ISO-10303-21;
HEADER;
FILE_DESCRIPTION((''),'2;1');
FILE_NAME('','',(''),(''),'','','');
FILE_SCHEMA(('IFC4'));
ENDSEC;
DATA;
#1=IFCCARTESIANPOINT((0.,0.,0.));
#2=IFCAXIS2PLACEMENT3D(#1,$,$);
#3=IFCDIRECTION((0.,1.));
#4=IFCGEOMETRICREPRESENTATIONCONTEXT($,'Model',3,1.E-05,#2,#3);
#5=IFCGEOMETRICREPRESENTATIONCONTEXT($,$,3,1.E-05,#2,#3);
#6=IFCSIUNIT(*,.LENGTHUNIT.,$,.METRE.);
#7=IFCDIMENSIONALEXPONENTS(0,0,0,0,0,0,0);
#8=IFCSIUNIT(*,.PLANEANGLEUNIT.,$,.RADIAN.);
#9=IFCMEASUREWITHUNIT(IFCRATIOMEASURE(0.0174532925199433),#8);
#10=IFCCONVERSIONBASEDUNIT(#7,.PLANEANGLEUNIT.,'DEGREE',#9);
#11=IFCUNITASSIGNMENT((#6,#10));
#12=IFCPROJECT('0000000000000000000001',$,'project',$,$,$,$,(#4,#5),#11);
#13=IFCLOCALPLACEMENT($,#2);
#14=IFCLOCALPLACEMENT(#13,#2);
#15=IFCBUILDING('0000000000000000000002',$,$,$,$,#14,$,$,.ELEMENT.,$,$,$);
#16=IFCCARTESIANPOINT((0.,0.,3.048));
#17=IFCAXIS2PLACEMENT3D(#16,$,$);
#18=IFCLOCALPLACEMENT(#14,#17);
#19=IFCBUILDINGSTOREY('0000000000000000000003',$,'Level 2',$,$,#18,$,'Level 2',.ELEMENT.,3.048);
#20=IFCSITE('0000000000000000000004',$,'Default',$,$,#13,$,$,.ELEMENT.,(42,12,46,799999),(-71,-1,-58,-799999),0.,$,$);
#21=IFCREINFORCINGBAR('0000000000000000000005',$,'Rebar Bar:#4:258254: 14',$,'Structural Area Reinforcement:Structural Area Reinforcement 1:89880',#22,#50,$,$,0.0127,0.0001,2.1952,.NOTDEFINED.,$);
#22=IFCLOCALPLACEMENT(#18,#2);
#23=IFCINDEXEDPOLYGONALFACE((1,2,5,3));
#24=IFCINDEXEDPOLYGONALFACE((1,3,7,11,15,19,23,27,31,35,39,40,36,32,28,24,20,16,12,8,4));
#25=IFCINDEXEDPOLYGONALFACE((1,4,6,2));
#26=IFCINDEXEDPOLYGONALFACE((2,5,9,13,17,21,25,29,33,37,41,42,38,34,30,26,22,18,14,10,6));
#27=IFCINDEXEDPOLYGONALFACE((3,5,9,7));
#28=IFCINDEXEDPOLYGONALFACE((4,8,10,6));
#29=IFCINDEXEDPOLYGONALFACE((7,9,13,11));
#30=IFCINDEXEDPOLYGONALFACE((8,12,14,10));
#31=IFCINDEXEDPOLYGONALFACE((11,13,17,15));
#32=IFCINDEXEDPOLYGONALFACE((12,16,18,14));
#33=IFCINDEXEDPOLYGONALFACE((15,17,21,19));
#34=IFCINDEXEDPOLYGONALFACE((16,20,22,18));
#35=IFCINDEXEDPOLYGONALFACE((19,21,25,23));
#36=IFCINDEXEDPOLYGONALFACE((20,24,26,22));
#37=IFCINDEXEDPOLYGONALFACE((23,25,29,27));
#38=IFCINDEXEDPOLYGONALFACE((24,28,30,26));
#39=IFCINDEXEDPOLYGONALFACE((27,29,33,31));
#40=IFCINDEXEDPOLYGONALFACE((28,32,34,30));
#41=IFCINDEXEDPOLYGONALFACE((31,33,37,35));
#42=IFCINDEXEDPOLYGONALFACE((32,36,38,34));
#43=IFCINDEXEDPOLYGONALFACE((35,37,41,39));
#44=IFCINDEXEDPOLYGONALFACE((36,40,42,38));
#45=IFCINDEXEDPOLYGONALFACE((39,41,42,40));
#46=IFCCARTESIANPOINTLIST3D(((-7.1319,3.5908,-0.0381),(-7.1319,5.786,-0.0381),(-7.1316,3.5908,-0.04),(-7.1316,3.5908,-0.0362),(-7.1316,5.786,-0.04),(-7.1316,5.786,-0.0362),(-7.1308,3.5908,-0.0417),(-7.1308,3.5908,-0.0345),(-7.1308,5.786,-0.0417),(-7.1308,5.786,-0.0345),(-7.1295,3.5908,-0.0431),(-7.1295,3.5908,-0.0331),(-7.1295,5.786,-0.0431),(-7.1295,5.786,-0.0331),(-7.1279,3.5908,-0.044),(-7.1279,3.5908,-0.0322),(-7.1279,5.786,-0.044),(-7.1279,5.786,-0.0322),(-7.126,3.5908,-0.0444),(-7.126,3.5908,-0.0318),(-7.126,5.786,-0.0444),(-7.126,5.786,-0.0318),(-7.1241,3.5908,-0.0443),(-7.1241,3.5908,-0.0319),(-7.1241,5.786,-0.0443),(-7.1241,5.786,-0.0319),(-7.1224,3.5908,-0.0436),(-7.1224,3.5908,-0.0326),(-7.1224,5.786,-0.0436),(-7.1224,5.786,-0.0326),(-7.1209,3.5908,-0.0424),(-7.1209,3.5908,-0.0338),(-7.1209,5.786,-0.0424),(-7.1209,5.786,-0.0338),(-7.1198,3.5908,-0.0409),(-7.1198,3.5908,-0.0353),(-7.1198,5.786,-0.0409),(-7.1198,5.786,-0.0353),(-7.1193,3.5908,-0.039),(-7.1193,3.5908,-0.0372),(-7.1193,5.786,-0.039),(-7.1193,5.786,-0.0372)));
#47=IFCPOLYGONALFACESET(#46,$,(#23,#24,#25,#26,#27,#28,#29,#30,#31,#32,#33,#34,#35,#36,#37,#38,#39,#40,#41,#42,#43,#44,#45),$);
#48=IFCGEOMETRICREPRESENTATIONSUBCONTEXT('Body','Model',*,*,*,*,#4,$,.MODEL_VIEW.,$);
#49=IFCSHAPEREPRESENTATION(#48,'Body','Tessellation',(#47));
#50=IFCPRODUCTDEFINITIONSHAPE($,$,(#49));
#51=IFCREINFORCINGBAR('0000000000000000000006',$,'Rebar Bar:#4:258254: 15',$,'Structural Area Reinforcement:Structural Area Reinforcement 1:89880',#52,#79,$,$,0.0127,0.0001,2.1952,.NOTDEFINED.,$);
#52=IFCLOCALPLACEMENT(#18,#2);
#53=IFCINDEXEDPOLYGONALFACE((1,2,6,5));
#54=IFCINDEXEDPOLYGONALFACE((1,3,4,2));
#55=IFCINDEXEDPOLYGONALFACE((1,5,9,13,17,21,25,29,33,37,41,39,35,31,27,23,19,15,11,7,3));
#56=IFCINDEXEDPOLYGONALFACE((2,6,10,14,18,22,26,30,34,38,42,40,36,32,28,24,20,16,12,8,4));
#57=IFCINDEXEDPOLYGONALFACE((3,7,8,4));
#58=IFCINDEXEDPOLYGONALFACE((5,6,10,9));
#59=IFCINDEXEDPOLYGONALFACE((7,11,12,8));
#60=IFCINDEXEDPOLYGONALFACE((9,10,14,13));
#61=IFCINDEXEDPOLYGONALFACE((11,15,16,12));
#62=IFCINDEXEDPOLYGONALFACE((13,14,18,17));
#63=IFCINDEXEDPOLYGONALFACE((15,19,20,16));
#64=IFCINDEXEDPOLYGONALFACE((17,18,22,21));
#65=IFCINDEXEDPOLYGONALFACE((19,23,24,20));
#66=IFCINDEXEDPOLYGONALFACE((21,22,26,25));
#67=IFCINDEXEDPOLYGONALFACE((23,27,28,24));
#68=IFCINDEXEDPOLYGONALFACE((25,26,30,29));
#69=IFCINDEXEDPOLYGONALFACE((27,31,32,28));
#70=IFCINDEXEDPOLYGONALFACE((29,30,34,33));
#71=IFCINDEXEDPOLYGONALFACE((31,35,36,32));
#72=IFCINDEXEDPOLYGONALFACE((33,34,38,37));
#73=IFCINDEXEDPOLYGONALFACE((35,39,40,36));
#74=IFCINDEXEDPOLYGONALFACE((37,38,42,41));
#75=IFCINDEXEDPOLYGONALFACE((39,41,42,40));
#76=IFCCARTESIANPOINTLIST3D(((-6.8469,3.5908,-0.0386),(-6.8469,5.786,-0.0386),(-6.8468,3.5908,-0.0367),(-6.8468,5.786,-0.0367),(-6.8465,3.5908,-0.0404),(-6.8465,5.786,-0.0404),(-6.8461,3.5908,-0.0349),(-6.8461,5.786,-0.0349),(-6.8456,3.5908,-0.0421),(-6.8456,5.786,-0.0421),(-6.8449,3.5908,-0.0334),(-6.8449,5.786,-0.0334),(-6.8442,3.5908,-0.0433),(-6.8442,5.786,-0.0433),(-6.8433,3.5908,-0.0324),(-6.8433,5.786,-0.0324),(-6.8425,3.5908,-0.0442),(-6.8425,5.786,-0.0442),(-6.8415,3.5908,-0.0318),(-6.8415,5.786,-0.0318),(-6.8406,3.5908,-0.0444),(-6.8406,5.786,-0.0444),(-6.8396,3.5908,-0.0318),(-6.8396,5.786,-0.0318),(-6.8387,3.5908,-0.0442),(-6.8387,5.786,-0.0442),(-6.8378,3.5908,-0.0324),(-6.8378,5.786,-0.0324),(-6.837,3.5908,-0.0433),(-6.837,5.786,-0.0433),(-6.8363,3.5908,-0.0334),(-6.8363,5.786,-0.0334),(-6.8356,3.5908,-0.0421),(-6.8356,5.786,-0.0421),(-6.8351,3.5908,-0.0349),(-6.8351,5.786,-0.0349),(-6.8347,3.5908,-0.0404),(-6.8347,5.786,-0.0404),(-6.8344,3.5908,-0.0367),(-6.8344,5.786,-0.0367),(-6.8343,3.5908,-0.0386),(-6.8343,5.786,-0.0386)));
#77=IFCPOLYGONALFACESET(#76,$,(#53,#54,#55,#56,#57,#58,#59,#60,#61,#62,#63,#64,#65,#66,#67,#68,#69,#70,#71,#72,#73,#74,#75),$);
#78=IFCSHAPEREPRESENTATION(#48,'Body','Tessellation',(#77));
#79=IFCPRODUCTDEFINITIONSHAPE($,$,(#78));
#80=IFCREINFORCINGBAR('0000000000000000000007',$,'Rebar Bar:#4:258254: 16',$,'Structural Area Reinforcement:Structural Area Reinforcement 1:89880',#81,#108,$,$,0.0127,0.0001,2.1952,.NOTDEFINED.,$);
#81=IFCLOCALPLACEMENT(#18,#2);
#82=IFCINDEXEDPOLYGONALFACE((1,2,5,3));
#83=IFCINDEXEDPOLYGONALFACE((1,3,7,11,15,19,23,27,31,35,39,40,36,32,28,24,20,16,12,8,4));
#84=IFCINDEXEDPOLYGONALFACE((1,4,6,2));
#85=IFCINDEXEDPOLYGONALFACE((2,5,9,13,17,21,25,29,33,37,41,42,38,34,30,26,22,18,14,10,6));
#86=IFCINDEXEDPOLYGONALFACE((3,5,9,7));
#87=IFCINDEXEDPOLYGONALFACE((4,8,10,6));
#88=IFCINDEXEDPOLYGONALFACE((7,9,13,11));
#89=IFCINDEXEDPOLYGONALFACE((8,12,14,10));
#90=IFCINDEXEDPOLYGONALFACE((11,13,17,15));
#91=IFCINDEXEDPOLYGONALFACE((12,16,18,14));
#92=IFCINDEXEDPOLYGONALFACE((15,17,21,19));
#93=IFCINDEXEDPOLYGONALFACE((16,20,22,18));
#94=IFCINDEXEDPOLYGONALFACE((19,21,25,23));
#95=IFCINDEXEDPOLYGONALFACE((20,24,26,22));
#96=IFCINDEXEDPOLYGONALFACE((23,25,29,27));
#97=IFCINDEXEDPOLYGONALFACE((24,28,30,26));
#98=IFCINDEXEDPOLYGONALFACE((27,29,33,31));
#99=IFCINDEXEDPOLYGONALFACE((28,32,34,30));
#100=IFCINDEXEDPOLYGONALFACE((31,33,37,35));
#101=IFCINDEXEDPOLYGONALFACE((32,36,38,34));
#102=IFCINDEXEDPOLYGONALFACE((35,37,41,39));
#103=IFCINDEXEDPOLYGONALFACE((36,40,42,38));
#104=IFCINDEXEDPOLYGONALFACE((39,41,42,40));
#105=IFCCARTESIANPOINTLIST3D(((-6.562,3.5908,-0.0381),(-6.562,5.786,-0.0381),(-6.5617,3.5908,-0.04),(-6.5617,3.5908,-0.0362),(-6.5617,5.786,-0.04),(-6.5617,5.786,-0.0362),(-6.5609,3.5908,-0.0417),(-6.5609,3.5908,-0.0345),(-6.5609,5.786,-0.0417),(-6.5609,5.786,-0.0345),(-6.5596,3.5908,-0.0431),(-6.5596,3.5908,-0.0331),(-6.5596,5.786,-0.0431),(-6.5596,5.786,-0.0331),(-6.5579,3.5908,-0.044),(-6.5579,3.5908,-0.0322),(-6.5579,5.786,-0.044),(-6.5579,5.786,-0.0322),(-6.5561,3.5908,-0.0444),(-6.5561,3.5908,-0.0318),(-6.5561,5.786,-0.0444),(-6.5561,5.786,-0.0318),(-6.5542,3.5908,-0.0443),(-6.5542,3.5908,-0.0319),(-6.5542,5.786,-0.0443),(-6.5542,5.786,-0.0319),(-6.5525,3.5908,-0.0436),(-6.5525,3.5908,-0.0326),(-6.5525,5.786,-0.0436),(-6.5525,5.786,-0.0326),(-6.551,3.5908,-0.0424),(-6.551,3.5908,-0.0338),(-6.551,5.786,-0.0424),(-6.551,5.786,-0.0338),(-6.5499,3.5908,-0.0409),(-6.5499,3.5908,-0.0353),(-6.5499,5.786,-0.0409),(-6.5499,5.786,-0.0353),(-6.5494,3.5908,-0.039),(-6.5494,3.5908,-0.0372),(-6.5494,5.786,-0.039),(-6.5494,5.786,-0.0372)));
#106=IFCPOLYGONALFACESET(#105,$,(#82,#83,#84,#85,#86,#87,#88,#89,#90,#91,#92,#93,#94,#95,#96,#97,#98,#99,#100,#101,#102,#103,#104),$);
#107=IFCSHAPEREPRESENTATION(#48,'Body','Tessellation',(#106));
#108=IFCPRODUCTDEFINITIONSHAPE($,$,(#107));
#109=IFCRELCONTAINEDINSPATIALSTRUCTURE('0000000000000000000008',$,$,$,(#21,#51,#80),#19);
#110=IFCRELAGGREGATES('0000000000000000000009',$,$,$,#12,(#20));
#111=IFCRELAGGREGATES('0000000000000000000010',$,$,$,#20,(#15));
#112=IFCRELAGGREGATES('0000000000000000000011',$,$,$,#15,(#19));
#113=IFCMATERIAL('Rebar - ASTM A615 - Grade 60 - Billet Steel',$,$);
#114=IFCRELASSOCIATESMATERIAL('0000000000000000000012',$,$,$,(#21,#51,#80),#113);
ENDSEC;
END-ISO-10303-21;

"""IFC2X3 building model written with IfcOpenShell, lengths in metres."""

from ifc_helpers import new_model, entity, si_unit, converted_unit, direction, frame, origin, place, context, subcontext, project, spatial, material, element, save


model = new_model("IFC2X3")

# Units and contexts
model_context = context("Model", 3, precision=1e-05, world=origin(), true_north=direction((0.0, 1.0)))
context_of_model = context(None, 3, precision=1e-05, world=origin(), true_north=direction((0.0, 1.0)))
body_context = subcontext(model_context, "Body", "Model", "MODEL_VIEW")
ifc_project = project(units=[si_unit("LENGTHUNIT", "METRE"), converted_unit("PLANEANGLEUNIT", "DEGREE", entity("IfcRatioMeasure", 0.0174532925199433), si_unit("PLANEANGLEUNIT", "RADIAN"), dimensions=[0, 0, 0, 0, 0, 0, 0])], contexts=[model_context, context_of_model])

# Site, building, storey
site_placement = place(None, origin())
site = spatial("IfcSite", under=ifc_project, at=site_placement, Name="Default", CompositionType="ELEMENT", RefLatitude=(42, 12, 46, 799999), RefLongitude=(-71, -1, -58, -799999), RefElevation=0.0)
building_placement = place(site_placement, origin())
building = spatial("IfcBuilding", under=site, at=building_placement, CompositionType="ELEMENT")
storey_placement = place(building_placement, frame((0.0, 0.0, 3.048)))
storey = spatial("IfcBuildingStorey", under=building, at=storey_placement, Name="Level 2", LongName="Level 2", CompositionType="ELEMENT", Elevation=3.048)

# Reinforcing bars
ifc_material_1 = material(Name="Rebar - ASTM A615 - Grade 60 - Billet Steel")
reinforcing_bar_1_placement = place(storey_placement, origin())
element("IfcReinforcingBar", 1, at=reinforcing_bar_1_placement, inside=storey, material=ifc_material_1, Name="Rebar Bar:#4:258254: 14", ObjectType="Structural Area Reinforcement:Structural Area Reinforcement 1:89880", BarLength=2.1952, BarRole="NOTDEFINED", CrossSectionArea=0.0001, NominalDiameter=0.0127, context=body_context, shape_type="AdvancedSweptSolid", body=[
    entity("IfcSweptDiskSolid", entity("IfcCompositeCurve", [entity("IfcCompositeCurveSegment", "CONTINUOUS", True, entity("IfcPolyline", [entity("IfcCartesianPoint", [-7.1255, 5.786, -0.0381]), entity("IfcCartesianPoint", [-7.1255, 3.5908, -0.0381])]))], False), 0.0063, None, 0.0, 1.0),
])
reinforcing_bar_2_placement = place(storey_placement, origin())
element("IfcReinforcingBar", 2, at=reinforcing_bar_2_placement, inside=storey, material=ifc_material_1, Name="Rebar Bar:#4:258254: 15", ObjectType="Structural Area Reinforcement:Structural Area Reinforcement 1:89880", BarLength=2.1952, BarRole="NOTDEFINED", CrossSectionArea=0.0001, NominalDiameter=0.0127, context=body_context, shape_type="AdvancedSweptSolid", body=[
    entity("IfcSweptDiskSolid", entity("IfcCompositeCurve", [entity("IfcCompositeCurveSegment", "CONTINUOUS", True, entity("IfcPolyline", [entity("IfcCartesianPoint", [-6.8406, 5.786, -0.0381]), entity("IfcCartesianPoint", [-6.8406, 3.5908, -0.0381])]))], False), 0.0063, None, 0.0, 1.0),
])
reinforcing_bar_3_placement = place(storey_placement, origin())
element("IfcReinforcingBar", 3, at=reinforcing_bar_3_placement, inside=storey, material=ifc_material_1, Name="Rebar Bar:#4:258254: 16", ObjectType="Structural Area Reinforcement:Structural Area Reinforcement 1:89880", BarLength=2.1952, BarRole="NOTDEFINED", CrossSectionArea=0.0001, NominalDiameter=0.0127, context=body_context, shape_type="AdvancedSweptSolid", body=[
    entity("IfcSweptDiskSolid", entity("IfcCompositeCurve", [entity("IfcCompositeCurveSegment", "CONTINUOUS", True, entity("IfcPolyline", [entity("IfcCartesianPoint", [-6.5556, 5.786, -0.0381]), entity("IfcCartesianPoint", [-6.5556, 3.5908, -0.0381])]))], False), 0.0063, None, 0.0, 1.0),
])

save(model, "model.ifc")
